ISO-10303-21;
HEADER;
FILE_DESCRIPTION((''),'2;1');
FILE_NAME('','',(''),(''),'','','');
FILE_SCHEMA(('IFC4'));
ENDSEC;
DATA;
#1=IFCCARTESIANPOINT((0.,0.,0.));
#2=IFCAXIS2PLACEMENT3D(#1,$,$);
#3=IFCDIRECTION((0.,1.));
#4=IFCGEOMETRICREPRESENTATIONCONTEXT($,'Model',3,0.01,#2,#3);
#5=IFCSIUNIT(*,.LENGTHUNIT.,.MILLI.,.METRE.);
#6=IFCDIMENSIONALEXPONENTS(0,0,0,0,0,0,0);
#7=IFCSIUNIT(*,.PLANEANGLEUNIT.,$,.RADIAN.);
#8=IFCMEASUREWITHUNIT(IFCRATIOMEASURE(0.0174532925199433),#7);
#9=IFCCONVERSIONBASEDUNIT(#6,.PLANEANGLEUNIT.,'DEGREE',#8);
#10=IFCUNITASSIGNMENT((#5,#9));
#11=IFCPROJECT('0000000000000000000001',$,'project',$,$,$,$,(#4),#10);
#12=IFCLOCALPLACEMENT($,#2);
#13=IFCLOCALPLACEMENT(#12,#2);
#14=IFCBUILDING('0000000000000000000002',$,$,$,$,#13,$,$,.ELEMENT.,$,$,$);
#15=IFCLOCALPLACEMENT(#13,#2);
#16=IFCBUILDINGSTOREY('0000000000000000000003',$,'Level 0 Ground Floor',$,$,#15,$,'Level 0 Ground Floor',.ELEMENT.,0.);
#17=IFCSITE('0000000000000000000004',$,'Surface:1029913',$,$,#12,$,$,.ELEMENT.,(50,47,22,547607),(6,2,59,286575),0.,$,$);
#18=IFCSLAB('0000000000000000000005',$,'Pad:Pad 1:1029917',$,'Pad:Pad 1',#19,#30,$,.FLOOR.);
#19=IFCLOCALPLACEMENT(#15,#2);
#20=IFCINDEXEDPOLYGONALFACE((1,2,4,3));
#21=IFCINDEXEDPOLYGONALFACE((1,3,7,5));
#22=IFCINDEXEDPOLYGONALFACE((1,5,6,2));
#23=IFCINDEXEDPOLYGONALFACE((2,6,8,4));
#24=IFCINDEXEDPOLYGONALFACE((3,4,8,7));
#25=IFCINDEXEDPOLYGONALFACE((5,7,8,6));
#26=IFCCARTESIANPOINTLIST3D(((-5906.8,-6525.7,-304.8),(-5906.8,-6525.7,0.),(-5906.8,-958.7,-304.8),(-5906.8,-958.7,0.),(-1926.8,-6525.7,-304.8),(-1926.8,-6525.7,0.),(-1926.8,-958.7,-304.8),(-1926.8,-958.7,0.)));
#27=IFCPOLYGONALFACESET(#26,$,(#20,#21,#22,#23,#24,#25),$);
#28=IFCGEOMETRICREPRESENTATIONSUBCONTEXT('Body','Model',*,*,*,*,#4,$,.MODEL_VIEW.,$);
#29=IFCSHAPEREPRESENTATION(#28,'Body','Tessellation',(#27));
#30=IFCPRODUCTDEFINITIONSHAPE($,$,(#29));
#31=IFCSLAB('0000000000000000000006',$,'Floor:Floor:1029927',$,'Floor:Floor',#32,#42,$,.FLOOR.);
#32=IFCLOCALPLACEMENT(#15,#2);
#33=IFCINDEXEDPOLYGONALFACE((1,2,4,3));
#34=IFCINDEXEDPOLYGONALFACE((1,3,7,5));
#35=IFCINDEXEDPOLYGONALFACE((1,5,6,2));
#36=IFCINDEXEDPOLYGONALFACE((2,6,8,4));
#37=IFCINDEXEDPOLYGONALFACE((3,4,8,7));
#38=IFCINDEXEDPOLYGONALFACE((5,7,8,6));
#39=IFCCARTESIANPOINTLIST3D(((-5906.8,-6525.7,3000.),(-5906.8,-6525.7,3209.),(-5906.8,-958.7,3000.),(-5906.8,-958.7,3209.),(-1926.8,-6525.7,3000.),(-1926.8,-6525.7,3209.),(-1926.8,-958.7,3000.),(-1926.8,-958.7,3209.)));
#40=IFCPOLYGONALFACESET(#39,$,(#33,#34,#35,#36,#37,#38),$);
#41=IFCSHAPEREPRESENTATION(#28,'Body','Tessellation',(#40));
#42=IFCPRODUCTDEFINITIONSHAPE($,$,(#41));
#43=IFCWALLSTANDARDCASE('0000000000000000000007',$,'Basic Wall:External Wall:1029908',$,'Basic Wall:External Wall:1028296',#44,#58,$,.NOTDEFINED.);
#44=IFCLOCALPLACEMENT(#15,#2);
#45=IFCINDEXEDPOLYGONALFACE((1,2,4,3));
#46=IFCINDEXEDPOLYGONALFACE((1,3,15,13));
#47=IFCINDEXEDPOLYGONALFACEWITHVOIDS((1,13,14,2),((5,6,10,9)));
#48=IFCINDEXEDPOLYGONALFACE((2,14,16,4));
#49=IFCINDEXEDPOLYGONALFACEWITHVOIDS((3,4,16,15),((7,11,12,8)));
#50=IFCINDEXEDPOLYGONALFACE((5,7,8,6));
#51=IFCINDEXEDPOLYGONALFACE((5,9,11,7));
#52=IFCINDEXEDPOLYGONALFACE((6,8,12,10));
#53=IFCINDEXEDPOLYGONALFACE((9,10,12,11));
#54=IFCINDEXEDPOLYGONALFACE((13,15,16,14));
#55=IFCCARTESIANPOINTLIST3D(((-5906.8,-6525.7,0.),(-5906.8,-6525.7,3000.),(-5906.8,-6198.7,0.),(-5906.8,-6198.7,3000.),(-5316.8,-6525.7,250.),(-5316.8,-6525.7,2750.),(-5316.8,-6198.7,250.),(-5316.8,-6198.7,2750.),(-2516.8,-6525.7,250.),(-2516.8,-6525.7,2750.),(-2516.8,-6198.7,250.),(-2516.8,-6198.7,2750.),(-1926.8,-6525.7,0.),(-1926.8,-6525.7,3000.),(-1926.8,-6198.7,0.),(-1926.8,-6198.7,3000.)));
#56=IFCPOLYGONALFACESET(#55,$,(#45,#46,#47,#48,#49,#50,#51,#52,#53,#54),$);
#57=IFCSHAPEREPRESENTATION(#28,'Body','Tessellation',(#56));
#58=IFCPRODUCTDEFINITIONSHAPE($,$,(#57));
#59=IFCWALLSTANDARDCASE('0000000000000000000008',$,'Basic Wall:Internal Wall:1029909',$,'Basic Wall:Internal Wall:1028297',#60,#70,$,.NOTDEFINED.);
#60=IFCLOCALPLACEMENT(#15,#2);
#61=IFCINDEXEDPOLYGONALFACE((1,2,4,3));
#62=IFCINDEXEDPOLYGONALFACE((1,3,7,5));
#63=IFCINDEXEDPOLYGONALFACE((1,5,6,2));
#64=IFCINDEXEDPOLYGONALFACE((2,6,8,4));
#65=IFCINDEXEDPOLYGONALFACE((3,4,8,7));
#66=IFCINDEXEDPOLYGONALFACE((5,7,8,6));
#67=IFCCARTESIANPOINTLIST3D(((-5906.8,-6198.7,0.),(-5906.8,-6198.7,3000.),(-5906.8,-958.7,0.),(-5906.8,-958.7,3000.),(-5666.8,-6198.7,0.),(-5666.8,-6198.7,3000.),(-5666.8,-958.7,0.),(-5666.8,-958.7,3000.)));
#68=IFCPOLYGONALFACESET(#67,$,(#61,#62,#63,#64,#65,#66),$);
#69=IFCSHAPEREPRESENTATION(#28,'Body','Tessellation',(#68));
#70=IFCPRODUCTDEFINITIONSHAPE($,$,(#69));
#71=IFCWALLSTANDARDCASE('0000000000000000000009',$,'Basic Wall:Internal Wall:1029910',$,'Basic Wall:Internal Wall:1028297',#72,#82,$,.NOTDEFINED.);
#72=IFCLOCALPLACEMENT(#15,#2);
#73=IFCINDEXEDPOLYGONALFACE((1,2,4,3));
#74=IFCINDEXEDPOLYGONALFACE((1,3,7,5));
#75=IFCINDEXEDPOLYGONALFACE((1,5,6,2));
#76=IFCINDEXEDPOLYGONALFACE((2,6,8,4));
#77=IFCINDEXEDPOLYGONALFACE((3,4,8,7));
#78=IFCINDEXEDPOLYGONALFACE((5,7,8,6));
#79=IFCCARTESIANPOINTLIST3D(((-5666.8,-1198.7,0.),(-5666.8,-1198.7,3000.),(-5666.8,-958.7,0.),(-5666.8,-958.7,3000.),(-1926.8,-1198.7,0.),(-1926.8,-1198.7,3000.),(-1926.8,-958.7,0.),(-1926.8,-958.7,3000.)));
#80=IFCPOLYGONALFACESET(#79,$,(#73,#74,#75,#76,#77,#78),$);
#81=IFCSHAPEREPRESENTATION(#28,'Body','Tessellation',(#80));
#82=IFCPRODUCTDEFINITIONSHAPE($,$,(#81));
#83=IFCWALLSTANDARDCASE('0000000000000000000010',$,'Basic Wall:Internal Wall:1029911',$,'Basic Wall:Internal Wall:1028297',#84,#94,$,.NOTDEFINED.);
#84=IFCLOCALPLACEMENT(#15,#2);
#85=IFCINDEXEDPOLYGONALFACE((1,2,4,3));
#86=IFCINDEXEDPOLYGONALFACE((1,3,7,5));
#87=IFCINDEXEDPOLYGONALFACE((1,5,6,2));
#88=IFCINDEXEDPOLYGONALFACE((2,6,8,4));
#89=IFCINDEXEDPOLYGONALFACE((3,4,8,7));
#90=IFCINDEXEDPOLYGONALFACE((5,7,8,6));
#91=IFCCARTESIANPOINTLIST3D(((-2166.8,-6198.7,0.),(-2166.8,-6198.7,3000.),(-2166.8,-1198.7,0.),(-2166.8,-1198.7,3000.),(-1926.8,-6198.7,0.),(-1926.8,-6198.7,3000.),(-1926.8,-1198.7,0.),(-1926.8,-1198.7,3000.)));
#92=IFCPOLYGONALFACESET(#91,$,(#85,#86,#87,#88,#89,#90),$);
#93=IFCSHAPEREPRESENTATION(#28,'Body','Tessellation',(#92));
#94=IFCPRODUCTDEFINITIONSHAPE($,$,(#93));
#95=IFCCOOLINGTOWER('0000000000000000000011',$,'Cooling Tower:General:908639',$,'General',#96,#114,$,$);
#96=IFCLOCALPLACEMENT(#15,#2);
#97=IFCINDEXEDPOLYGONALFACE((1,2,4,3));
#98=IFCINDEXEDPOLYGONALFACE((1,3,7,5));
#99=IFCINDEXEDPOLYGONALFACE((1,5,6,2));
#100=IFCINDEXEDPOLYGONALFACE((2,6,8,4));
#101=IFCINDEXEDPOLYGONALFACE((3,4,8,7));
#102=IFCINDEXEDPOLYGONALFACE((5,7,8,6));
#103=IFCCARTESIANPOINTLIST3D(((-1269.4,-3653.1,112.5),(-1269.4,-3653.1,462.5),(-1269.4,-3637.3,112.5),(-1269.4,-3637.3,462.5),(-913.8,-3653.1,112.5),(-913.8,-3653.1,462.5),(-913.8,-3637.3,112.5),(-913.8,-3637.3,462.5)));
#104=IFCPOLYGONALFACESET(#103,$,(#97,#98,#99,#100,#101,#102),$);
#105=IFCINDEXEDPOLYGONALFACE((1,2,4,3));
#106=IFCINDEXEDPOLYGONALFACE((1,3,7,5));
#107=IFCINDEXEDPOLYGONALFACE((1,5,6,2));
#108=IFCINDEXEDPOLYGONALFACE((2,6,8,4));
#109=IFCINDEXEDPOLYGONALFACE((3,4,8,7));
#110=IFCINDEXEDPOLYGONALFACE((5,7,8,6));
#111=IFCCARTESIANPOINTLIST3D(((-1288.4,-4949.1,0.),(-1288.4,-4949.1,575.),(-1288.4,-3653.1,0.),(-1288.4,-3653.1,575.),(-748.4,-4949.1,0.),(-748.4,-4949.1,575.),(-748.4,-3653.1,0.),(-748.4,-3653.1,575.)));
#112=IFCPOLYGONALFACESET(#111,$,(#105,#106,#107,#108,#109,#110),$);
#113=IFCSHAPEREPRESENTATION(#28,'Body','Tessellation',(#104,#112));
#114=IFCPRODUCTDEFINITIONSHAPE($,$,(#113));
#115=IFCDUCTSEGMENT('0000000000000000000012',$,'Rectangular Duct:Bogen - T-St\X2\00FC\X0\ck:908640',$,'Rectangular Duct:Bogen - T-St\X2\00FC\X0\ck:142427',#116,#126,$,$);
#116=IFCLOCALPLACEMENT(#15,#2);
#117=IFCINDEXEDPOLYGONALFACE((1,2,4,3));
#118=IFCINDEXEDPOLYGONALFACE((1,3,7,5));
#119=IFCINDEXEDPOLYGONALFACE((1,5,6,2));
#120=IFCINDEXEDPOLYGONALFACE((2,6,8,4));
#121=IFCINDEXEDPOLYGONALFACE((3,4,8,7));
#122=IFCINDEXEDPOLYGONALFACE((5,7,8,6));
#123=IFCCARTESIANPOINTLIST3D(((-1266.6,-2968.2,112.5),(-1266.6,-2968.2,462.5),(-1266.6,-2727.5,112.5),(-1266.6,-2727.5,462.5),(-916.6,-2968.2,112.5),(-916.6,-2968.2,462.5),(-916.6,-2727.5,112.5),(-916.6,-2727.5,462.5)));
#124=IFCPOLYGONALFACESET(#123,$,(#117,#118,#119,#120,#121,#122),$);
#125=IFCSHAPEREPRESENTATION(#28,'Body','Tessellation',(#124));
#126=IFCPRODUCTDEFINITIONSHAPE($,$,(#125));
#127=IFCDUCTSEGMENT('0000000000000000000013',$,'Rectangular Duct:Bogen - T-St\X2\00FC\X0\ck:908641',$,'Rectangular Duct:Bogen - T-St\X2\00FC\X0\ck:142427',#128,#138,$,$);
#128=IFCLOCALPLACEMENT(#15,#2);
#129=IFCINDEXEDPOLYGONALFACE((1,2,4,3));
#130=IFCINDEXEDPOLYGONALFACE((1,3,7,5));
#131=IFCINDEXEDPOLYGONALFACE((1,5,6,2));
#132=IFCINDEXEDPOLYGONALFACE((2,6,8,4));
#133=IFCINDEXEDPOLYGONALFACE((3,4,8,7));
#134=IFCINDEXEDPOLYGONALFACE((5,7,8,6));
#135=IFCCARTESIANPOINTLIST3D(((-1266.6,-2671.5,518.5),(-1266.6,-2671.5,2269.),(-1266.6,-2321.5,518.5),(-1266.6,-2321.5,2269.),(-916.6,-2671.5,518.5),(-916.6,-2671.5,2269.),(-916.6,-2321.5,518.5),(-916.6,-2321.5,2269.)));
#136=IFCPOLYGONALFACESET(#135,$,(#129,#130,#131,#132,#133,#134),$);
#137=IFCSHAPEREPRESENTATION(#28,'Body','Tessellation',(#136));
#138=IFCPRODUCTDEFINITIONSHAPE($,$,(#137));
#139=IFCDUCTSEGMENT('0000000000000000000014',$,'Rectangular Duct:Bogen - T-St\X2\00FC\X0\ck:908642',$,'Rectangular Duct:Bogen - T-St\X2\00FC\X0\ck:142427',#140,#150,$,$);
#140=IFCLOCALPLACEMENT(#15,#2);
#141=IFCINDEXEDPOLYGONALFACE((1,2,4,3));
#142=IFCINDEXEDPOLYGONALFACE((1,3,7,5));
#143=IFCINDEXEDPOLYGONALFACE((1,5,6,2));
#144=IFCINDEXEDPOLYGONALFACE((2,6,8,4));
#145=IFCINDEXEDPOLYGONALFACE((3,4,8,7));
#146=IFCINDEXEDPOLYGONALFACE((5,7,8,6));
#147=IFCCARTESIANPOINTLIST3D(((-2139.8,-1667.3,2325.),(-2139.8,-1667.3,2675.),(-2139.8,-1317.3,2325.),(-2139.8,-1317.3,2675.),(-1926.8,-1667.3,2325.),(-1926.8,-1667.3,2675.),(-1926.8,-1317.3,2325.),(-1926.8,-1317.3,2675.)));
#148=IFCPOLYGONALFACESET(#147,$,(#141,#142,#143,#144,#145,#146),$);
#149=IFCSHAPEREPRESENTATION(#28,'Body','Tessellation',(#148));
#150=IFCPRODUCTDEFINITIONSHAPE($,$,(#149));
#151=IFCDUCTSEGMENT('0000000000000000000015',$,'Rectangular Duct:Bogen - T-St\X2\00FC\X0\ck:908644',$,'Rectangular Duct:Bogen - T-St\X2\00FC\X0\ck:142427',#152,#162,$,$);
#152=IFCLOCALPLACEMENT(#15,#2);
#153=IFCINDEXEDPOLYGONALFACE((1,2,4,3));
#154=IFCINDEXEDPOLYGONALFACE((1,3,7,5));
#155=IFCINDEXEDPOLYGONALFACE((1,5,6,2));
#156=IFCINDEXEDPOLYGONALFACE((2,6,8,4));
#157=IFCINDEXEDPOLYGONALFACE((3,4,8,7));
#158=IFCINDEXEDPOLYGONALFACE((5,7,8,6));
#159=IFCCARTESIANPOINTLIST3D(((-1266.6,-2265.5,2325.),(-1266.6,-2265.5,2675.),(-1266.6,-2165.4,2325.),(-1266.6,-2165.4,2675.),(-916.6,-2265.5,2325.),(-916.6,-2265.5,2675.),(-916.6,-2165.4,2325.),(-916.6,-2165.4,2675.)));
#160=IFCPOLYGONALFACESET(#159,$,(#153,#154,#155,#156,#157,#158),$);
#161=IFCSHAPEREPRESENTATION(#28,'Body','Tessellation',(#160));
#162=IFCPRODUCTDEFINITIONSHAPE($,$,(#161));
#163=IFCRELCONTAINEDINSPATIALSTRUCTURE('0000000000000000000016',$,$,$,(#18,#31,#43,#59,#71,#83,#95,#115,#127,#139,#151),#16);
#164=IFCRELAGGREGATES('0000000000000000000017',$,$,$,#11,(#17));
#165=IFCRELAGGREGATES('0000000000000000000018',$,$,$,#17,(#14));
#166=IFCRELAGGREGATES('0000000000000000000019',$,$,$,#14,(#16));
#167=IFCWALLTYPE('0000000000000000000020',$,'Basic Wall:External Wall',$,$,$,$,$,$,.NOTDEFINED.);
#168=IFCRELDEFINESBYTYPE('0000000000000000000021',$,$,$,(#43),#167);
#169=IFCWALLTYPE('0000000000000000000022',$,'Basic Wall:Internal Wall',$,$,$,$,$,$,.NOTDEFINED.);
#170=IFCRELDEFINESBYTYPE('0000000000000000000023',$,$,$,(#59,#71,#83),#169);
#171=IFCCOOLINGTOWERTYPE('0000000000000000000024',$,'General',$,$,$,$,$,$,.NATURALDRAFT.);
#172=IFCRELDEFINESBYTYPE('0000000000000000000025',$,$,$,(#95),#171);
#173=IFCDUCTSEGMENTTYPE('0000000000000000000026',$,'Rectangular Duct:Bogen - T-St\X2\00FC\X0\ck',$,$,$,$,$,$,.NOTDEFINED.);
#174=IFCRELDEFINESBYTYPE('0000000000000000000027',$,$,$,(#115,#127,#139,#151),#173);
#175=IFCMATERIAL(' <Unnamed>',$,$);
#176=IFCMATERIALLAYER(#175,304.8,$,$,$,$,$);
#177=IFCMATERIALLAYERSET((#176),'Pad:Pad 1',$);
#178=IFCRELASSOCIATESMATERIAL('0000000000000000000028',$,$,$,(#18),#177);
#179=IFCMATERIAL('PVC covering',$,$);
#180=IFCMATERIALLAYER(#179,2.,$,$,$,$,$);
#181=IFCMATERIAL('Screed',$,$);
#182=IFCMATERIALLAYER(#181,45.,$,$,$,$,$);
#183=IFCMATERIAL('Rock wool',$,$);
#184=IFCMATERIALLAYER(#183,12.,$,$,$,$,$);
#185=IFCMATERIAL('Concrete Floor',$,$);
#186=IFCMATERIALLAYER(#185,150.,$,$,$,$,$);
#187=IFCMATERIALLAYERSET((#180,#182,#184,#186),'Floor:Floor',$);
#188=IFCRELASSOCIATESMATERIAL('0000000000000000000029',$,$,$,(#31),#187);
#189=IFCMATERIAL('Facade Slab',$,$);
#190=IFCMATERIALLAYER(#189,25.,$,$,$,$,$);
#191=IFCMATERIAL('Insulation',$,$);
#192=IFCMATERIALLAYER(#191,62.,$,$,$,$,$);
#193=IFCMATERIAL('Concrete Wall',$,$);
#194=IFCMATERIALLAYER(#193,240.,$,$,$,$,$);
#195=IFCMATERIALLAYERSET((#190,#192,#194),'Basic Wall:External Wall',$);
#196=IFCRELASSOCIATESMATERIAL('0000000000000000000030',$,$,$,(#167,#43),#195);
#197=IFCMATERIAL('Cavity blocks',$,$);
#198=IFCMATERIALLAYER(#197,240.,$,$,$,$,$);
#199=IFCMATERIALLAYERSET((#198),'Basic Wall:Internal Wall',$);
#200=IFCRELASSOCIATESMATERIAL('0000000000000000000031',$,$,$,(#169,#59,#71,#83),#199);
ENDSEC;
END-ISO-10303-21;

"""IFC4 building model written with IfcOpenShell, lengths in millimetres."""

from ifc_helpers import new_model, entity, si_unit, converted_unit, direction, frame, frame_2d, origin, origin_2d_with_axis, place, context, subcontext, project, spatial, polyline, rectangle, extrude, clip, bounded_halfspace, source, transform, mapped, material, layer, layer_set, layer_usage, type_object, type_shapes, element, save


model = new_model("IFC4")

# Units and contexts
model_context = context("Model", 3, precision=0.01, world=origin(), true_north=direction((0.0, 1.0)))
body_context = subcontext(model_context, "Body", "Model", "MODEL_VIEW")
ifc_project = project(units=[si_unit("LENGTHUNIT", "METRE", prefix="MILLI"), converted_unit("PLANEANGLEUNIT", "DEGREE", entity("IfcRatioMeasure", 0.0174532925199433), si_unit("PLANEANGLEUNIT", "RADIAN"), dimensions=[0, 0, 0, 0, 0, 0, 0])], contexts=[model_context])

# Site, building, storey
site_placement = place(None, origin())
site = spatial("IfcSite", under=ifc_project, at=site_placement, Name="Surface:1029913", CompositionType="ELEMENT", RefLatitude=(50, 47, 22, 547607), RefLongitude=(6, 2, 59, 286575), RefElevation=0.0)
building_placement = place(site_placement, origin())
building = spatial("IfcBuilding", under=site, at=building_placement, CompositionType="ELEMENT")
storey_placement = place(building_placement, origin())
storey = spatial("IfcBuildingStorey", under=building, at=storey_placement, Name="Level 0 Ground Floor", LongName="Level 0 Ground Floor", CompositionType="ELEMENT", Elevation=0.0)

# Slabs
ifc_material_1 = material(Name=" <Unnamed>")
ifc_layer_1 = layer(ifc_material_1, 304.8)
ifc_layer_set_1 = layer_set([ifc_layer_1], Name="Pad:Pad 1")
ifc_layer_usage_1 = layer_usage(ifc_layer_set_1, "AXIS3", "NEGATIVE", 0.0)
slab_1_placement = place(storey_placement, frame((-5906.8, -6525.7, -304.8)))
element("IfcSlab", 1, at=slab_1_placement, inside=storey, material=ifc_layer_usage_1, Name="Pad:Pad 1:1029917", ObjectType="Pad:Pad 1", PredefinedType="FLOOR", context=body_context, shape_type="SweptSolid", body=[
    extrude(rectangle(XDim=5567.0, YDim=3980.0, at=frame_2d((0.0, 0.0), x_axis=(0.0, -1.0))), frame((1990.0, 2783.5, 304.8), z_axis=(0.0, 0.0, -1.0), x_axis=(-1.0, 0.0, 0.0)), (0.0, 0.0, 1.0), 304.8),
])
ifc_material_2 = material(Name="PVC covering")
ifc_layer_2 = layer(ifc_material_2, 2.0)
ifc_material_3 = material(Name="Screed")
ifc_layer_3 = layer(ifc_material_3, 45.0)
ifc_material_4 = material(Name="Rock wool")
ifc_layer_4 = layer(ifc_material_4, 12.0)
ifc_material_5 = material(Name="Concrete Floor")
ifc_layer_5 = layer(ifc_material_5, 150.0)
ifc_layer_set_2 = layer_set([ifc_layer_2, ifc_layer_3, ifc_layer_4, ifc_layer_5], Name="Floor:Floor")
ifc_layer_usage_2 = layer_usage(ifc_layer_set_2, "AXIS3", "POSITIVE", 0.0)
slab_2_placement = place(storey_placement, origin())
element("IfcSlab", 2, at=slab_2_placement, inside=storey, material=ifc_layer_usage_2, Name="Floor:Floor:1029927", ObjectType="Floor:Floor", PredefinedType="FLOOR", context=body_context, shape_type="SweptSolid", body=[
    extrude(rectangle(XDim=5567.0, YDim=3980.0, at=frame_2d((0.0, 0.0), x_axis=(1.0, 0.0))), frame((-3916.8, -3742.2, 3209.0), z_axis=(0.0, 0.0, -1.0), x_axis=(0.0, 1.0, 0.0)), (0.0, 0.0, 1.0), 209.0),
])

# Wall, opening
ifc_material_6 = material(Name="Facade Slab")
ifc_layer_6 = layer(ifc_material_6, 25.0)
ifc_material_7 = material(Name="Insulation")
ifc_layer_7 = layer(ifc_material_7, 62.0)
ifc_material_8 = material(Name="Concrete Wall")
ifc_layer_8 = layer(ifc_material_8, 240.0)
ifc_layer_set_3 = layer_set([ifc_layer_6, ifc_layer_7, ifc_layer_8], Name="Basic Wall:External Wall")
ifc_layer_usage_3 = layer_usage(ifc_layer_set_3, "AXIS2", "POSITIVE", -163.5)
wall_type_1 = type_object("IfcWallType", Name="Basic Wall:External Wall", PredefinedType="NOTDEFINED", material=ifc_layer_set_3)
wall_1_placement = place(storey_placement, frame((-5906.8, -6362.2, 0.0)))
wall_1 = element("IfcWallStandardCase", 3, at=wall_1_placement, inside=storey, type_object=wall_type_1, material=ifc_layer_usage_3, Name="Basic Wall:External Wall:1029908", ObjectType="Basic Wall:External Wall:1028296", PredefinedType="NOTDEFINED", context=body_context, shape_type="Clipping", body=[
    clip(extrude(rectangle(XDim=3980.0, YDim=327.0, at=frame_2d((1990.0, 0.0), x_axis=(-1.0, 0.0))), origin(), (0.0, 0.0, 1.0), 3000.0), bounded_halfspace(frame((0.0, -163.5, 3000.0), z_axis=(0.0, 0.0, -1.0), x_axis=(0.0, -1.0, 0.0)), True, frame((0.0, -163.5, 3000.0)), polyline([(0.0, 0.0), (3980.0, 0.0), (3980.0, 327.0), (3740.0, 327.0), (240.0, 327.0), (0.0, 327.0), (0.0, 0.0)]))),
])
opening_placement = place(wall_1_placement, frame((590.0, -163.5, 250.0)))
element("IfcOpeningElement", 4, at=opening_placement, cuts=wall_1, ObjectType="Opening", PredefinedType="OPENING", context=body_context, shape_type="SweptSolid", body=[
    extrude(rectangle(XDim=2500.0, YDim=2800.0, at=frame_2d((1250.0, 1400.0), x_axis=(1.0, 0.0))), frame((0.0, 0.0, 0.0), z_axis=(0.0, 1.0, 0.0), x_axis=(0.0, 0.0, 1.0)), (0.0, 0.0, 1.0), 327.0),
])

# Walls
ifc_material_9 = material(Name="Cavity blocks")
ifc_layer_9 = layer(ifc_material_9, 240.0)
ifc_layer_set_4 = layer_set([ifc_layer_9], Name="Basic Wall:Internal Wall")
ifc_layer_usage_4 = layer_usage(ifc_layer_set_4, "AXIS2", "NEGATIVE", 120.0)
wall_type_2 = type_object("IfcWallType", Name="Basic Wall:Internal Wall", PredefinedType="NOTDEFINED", material=ifc_layer_set_4)
wall_2_placement = place(storey_placement, frame((-5786.8, -6198.7, 0.0), z_axis=(0.0, 0.0, 1.0), x_axis=(0.0, 1.0, 0.0)))
element("IfcWallStandardCase", 5, at=wall_2_placement, inside=storey, type_object=wall_type_2, material=ifc_layer_usage_4, Name="Basic Wall:Internal Wall:1029909", ObjectType="Basic Wall:Internal Wall:1028297", PredefinedType="NOTDEFINED", context=body_context, shape_type="Clipping", body=[
    clip(extrude(rectangle(XDim=5240.0, YDim=240.0, at=frame_2d((2620.0, 0.0), x_axis=(-1.0, 0.0))), origin(), (0.0, 0.0, 1.0), 3000.0), bounded_halfspace(frame((0.0, -120.0, 3000.0), z_axis=(0.0, 0.0, -1.0), x_axis=(-1.0, 0.0, 0.0)), True, frame((0.0, -120.0, 3000.0)), polyline([(0.0, 0.0), (5000.0, 0.0), (5240.0, 0.0), (5240.0, 240.0), (0.0, 240.0), (0.0, 0.0)]))),
])
ifc_layer_usage_5 = layer_usage(ifc_layer_set_4, "AXIS2", "NEGATIVE", 120.0)
wall_3_placement = place(storey_placement, frame((-5666.8, -1078.7, 0.0)))
element("IfcWallStandardCase", 6, at=wall_3_placement, inside=storey, type_object=wall_type_2, material=ifc_layer_usage_5, Name="Basic Wall:Internal Wall:1029910", ObjectType="Basic Wall:Internal Wall:1028297", PredefinedType="NOTDEFINED", context=body_context, shape_type="Clipping", body=[
    clip(extrude(rectangle(XDim=3740.0, YDim=240.0, at=frame_2d((1870.0, 0.0), x_axis=(-1.0, 0.0))), origin(), (0.0, 0.0, 1.0), 3000.0), bounded_halfspace(frame((0.0, -120.0, 3000.0), z_axis=(0.0, 0.0, -1.0), x_axis=(0.0, -1.0, 0.0)), True, frame((0.0, -120.0, 3000.0)), polyline([(0.0, 0.0), (3500.0, 0.0), (3740.0, 0.0), (3740.0, 240.0), (0.0, 240.0), (0.0, 0.0)]))),
])
ifc_layer_usage_6 = layer_usage(ifc_layer_set_4, "AXIS2", "NEGATIVE", 120.0)
wall_4_placement = place(storey_placement, frame((-2046.8, -1198.7, 0.0), z_axis=(0.0, 0.0, 1.0), x_axis=(0.0, -1.0, 0.0)))
element("IfcWallStandardCase", 7, at=wall_4_placement, inside=storey, type_object=wall_type_2, material=ifc_layer_usage_6, Name="Basic Wall:Internal Wall:1029911", ObjectType="Basic Wall:Internal Wall:1028297", PredefinedType="NOTDEFINED", context=body_context, shape_type="Clipping", body=[
    clip(extrude(rectangle(XDim=5000.0, YDim=240.0, at=frame_2d((2500.0, 0.0), x_axis=(-1.0, 0.0))), origin(), (0.0, 0.0, 1.0), 3000.0), bounded_halfspace(frame((0.0, -120.0, 3000.0), z_axis=(0.0, 0.0, -1.0), x_axis=(1.0, 0.0, 0.0)), True, frame((0.0, -120.0, 3000.0)), polyline([(0.0, 0.0), (5000.0, 0.0), (5000.0, 240.0), (0.0, 240.0), (0.0, 0.0)]))),
])

# Cooling tower
cooling_tower_type = type_object("IfcCoolingTowerType", Name="General", PredefinedType="NATURALDRAFT")
shared_shape_1 = source(origin(), body_context, "Body", "SweptSolid", [
    extrude(rectangle(XDim=15.9, YDim=355.6, at=origin_2d_with_axis()), frame((1303.9, 343.2, 112.5)), (0.0, 0.0, 1.0), 350.0),
    extrude(rectangle(XDim=1296.0, YDim=540.0, at=origin_2d_with_axis()), frame((648.0, 270.0, 0.0), z_axis=(0.0, 0.0, 1.0), x_axis=(-1.0, 0.0, 0.0)), (0.0, 0.0, 1.0), 575.0),
])
type_shapes(cooling_tower_type, [shared_shape_1])
cooling_tower_placement = place(storey_placement, frame((-748.4, -4949.1, 0.0), z_axis=(0.0, 0.0, 1.0), x_axis=(0.0, 1.0, 0.0)))
element("IfcCoolingTower", 8, at=cooling_tower_placement, inside=storey, type_object=cooling_tower_type, Name="Cooling Tower:General:908639", ObjectType="General", context=body_context, shape_type="MappedRepresentation", body=[
    mapped(shared_shape_1, transform((0.0, 0.0, 0.0), scale=1.0)),
])

# Duct segments
duct_segment_type = type_object("IfcDuctSegmentType", Name="Rectangular Duct:Bogen - T-Stück", PredefinedType="NOTDEFINED")
duct_segment_1_placement = place(storey_placement, frame((-1266.6, -2968.2, 112.5)))
element("IfcDuctSegment", 9, at=duct_segment_1_placement, inside=storey, type_object=duct_segment_type, Name="Rectangular Duct:Bogen - T-Stück:908640", ObjectType="Rectangular Duct:Bogen - T-Stück:142427", context=body_context, shape_type="SweptSolid", body=[
    extrude(rectangle(XDim=240.7, YDim=350.0, at=origin_2d_with_axis()), frame((175.0, 120.4, 0.0), z_axis=(0.0, 0.0, 1.0), x_axis=(0.0, -1.0, 0.0)), (0.0, 0.0, 1.0), 350.0),
])
duct_segment_2_placement = place(storey_placement, frame((-1266.6, -2671.5, 518.5)))
element("IfcDuctSegment", 10, at=duct_segment_2_placement, inside=storey, type_object=duct_segment_type, Name="Rectangular Duct:Bogen - T-Stück:908641", ObjectType="Rectangular Duct:Bogen - T-Stück:142427", context=body_context, shape_type="SweptSolid", body=[
    extrude(rectangle(XDim=350.0, YDim=350.0, at=frame_2d((0.0, 0.0), x_axis=(1.0, 0.0))), frame((175.0, 175.0, 0.0), z_axis=(0.0, 0.0, 1.0), x_axis=(-1.0, 0.0, 0.0)), (0.0, 0.0, 1.0), 1750.5),
])
duct_segment_3_placement = place(storey_placement, frame((-2139.8, -1667.3, 2325.0)))
element("IfcDuctSegment", 11, at=duct_segment_3_placement, inside=storey, type_object=duct_segment_type, Name="Rectangular Duct:Bogen - T-Stück:908642", ObjectType="Rectangular Duct:Bogen - T-Stück:142427", context=body_context, shape_type="SweptSolid", body=[
    extrude(rectangle(XDim=213.0, YDim=350.0, at=frame_2d((0.0, 0.0), x_axis=(1.0, 0.0))), frame((106.5, 175.0, 0.0), z_axis=(0.0, 0.0, 1.0), x_axis=(-1.0, 0.0, 0.0)), (0.0, 0.0, 1.0), 350.0),
])
duct_segment_4_placement = place(storey_placement, frame((-1266.6, -2265.5, 2325.0)))
element("IfcDuctSegment", 12, at=duct_segment_4_placement, inside=storey, type_object=duct_segment_type, Name="Rectangular Duct:Bogen - T-Stück:908644", ObjectType="Rectangular Duct:Bogen - T-Stück:142427", context=body_context, shape_type="SweptSolid", body=[
    extrude(rectangle(XDim=100.1, YDim=350.0, at=frame_2d((0.0, 0.0), x_axis=(1.0, 0.0))), frame((175.0, 50.1, 0.0), z_axis=(0.0, 0.0, 1.0), x_axis=(0.0, -1.0, 0.0)), (0.0, 0.0, 1.0), 350.0),
])

save(model, "model.ifc")
